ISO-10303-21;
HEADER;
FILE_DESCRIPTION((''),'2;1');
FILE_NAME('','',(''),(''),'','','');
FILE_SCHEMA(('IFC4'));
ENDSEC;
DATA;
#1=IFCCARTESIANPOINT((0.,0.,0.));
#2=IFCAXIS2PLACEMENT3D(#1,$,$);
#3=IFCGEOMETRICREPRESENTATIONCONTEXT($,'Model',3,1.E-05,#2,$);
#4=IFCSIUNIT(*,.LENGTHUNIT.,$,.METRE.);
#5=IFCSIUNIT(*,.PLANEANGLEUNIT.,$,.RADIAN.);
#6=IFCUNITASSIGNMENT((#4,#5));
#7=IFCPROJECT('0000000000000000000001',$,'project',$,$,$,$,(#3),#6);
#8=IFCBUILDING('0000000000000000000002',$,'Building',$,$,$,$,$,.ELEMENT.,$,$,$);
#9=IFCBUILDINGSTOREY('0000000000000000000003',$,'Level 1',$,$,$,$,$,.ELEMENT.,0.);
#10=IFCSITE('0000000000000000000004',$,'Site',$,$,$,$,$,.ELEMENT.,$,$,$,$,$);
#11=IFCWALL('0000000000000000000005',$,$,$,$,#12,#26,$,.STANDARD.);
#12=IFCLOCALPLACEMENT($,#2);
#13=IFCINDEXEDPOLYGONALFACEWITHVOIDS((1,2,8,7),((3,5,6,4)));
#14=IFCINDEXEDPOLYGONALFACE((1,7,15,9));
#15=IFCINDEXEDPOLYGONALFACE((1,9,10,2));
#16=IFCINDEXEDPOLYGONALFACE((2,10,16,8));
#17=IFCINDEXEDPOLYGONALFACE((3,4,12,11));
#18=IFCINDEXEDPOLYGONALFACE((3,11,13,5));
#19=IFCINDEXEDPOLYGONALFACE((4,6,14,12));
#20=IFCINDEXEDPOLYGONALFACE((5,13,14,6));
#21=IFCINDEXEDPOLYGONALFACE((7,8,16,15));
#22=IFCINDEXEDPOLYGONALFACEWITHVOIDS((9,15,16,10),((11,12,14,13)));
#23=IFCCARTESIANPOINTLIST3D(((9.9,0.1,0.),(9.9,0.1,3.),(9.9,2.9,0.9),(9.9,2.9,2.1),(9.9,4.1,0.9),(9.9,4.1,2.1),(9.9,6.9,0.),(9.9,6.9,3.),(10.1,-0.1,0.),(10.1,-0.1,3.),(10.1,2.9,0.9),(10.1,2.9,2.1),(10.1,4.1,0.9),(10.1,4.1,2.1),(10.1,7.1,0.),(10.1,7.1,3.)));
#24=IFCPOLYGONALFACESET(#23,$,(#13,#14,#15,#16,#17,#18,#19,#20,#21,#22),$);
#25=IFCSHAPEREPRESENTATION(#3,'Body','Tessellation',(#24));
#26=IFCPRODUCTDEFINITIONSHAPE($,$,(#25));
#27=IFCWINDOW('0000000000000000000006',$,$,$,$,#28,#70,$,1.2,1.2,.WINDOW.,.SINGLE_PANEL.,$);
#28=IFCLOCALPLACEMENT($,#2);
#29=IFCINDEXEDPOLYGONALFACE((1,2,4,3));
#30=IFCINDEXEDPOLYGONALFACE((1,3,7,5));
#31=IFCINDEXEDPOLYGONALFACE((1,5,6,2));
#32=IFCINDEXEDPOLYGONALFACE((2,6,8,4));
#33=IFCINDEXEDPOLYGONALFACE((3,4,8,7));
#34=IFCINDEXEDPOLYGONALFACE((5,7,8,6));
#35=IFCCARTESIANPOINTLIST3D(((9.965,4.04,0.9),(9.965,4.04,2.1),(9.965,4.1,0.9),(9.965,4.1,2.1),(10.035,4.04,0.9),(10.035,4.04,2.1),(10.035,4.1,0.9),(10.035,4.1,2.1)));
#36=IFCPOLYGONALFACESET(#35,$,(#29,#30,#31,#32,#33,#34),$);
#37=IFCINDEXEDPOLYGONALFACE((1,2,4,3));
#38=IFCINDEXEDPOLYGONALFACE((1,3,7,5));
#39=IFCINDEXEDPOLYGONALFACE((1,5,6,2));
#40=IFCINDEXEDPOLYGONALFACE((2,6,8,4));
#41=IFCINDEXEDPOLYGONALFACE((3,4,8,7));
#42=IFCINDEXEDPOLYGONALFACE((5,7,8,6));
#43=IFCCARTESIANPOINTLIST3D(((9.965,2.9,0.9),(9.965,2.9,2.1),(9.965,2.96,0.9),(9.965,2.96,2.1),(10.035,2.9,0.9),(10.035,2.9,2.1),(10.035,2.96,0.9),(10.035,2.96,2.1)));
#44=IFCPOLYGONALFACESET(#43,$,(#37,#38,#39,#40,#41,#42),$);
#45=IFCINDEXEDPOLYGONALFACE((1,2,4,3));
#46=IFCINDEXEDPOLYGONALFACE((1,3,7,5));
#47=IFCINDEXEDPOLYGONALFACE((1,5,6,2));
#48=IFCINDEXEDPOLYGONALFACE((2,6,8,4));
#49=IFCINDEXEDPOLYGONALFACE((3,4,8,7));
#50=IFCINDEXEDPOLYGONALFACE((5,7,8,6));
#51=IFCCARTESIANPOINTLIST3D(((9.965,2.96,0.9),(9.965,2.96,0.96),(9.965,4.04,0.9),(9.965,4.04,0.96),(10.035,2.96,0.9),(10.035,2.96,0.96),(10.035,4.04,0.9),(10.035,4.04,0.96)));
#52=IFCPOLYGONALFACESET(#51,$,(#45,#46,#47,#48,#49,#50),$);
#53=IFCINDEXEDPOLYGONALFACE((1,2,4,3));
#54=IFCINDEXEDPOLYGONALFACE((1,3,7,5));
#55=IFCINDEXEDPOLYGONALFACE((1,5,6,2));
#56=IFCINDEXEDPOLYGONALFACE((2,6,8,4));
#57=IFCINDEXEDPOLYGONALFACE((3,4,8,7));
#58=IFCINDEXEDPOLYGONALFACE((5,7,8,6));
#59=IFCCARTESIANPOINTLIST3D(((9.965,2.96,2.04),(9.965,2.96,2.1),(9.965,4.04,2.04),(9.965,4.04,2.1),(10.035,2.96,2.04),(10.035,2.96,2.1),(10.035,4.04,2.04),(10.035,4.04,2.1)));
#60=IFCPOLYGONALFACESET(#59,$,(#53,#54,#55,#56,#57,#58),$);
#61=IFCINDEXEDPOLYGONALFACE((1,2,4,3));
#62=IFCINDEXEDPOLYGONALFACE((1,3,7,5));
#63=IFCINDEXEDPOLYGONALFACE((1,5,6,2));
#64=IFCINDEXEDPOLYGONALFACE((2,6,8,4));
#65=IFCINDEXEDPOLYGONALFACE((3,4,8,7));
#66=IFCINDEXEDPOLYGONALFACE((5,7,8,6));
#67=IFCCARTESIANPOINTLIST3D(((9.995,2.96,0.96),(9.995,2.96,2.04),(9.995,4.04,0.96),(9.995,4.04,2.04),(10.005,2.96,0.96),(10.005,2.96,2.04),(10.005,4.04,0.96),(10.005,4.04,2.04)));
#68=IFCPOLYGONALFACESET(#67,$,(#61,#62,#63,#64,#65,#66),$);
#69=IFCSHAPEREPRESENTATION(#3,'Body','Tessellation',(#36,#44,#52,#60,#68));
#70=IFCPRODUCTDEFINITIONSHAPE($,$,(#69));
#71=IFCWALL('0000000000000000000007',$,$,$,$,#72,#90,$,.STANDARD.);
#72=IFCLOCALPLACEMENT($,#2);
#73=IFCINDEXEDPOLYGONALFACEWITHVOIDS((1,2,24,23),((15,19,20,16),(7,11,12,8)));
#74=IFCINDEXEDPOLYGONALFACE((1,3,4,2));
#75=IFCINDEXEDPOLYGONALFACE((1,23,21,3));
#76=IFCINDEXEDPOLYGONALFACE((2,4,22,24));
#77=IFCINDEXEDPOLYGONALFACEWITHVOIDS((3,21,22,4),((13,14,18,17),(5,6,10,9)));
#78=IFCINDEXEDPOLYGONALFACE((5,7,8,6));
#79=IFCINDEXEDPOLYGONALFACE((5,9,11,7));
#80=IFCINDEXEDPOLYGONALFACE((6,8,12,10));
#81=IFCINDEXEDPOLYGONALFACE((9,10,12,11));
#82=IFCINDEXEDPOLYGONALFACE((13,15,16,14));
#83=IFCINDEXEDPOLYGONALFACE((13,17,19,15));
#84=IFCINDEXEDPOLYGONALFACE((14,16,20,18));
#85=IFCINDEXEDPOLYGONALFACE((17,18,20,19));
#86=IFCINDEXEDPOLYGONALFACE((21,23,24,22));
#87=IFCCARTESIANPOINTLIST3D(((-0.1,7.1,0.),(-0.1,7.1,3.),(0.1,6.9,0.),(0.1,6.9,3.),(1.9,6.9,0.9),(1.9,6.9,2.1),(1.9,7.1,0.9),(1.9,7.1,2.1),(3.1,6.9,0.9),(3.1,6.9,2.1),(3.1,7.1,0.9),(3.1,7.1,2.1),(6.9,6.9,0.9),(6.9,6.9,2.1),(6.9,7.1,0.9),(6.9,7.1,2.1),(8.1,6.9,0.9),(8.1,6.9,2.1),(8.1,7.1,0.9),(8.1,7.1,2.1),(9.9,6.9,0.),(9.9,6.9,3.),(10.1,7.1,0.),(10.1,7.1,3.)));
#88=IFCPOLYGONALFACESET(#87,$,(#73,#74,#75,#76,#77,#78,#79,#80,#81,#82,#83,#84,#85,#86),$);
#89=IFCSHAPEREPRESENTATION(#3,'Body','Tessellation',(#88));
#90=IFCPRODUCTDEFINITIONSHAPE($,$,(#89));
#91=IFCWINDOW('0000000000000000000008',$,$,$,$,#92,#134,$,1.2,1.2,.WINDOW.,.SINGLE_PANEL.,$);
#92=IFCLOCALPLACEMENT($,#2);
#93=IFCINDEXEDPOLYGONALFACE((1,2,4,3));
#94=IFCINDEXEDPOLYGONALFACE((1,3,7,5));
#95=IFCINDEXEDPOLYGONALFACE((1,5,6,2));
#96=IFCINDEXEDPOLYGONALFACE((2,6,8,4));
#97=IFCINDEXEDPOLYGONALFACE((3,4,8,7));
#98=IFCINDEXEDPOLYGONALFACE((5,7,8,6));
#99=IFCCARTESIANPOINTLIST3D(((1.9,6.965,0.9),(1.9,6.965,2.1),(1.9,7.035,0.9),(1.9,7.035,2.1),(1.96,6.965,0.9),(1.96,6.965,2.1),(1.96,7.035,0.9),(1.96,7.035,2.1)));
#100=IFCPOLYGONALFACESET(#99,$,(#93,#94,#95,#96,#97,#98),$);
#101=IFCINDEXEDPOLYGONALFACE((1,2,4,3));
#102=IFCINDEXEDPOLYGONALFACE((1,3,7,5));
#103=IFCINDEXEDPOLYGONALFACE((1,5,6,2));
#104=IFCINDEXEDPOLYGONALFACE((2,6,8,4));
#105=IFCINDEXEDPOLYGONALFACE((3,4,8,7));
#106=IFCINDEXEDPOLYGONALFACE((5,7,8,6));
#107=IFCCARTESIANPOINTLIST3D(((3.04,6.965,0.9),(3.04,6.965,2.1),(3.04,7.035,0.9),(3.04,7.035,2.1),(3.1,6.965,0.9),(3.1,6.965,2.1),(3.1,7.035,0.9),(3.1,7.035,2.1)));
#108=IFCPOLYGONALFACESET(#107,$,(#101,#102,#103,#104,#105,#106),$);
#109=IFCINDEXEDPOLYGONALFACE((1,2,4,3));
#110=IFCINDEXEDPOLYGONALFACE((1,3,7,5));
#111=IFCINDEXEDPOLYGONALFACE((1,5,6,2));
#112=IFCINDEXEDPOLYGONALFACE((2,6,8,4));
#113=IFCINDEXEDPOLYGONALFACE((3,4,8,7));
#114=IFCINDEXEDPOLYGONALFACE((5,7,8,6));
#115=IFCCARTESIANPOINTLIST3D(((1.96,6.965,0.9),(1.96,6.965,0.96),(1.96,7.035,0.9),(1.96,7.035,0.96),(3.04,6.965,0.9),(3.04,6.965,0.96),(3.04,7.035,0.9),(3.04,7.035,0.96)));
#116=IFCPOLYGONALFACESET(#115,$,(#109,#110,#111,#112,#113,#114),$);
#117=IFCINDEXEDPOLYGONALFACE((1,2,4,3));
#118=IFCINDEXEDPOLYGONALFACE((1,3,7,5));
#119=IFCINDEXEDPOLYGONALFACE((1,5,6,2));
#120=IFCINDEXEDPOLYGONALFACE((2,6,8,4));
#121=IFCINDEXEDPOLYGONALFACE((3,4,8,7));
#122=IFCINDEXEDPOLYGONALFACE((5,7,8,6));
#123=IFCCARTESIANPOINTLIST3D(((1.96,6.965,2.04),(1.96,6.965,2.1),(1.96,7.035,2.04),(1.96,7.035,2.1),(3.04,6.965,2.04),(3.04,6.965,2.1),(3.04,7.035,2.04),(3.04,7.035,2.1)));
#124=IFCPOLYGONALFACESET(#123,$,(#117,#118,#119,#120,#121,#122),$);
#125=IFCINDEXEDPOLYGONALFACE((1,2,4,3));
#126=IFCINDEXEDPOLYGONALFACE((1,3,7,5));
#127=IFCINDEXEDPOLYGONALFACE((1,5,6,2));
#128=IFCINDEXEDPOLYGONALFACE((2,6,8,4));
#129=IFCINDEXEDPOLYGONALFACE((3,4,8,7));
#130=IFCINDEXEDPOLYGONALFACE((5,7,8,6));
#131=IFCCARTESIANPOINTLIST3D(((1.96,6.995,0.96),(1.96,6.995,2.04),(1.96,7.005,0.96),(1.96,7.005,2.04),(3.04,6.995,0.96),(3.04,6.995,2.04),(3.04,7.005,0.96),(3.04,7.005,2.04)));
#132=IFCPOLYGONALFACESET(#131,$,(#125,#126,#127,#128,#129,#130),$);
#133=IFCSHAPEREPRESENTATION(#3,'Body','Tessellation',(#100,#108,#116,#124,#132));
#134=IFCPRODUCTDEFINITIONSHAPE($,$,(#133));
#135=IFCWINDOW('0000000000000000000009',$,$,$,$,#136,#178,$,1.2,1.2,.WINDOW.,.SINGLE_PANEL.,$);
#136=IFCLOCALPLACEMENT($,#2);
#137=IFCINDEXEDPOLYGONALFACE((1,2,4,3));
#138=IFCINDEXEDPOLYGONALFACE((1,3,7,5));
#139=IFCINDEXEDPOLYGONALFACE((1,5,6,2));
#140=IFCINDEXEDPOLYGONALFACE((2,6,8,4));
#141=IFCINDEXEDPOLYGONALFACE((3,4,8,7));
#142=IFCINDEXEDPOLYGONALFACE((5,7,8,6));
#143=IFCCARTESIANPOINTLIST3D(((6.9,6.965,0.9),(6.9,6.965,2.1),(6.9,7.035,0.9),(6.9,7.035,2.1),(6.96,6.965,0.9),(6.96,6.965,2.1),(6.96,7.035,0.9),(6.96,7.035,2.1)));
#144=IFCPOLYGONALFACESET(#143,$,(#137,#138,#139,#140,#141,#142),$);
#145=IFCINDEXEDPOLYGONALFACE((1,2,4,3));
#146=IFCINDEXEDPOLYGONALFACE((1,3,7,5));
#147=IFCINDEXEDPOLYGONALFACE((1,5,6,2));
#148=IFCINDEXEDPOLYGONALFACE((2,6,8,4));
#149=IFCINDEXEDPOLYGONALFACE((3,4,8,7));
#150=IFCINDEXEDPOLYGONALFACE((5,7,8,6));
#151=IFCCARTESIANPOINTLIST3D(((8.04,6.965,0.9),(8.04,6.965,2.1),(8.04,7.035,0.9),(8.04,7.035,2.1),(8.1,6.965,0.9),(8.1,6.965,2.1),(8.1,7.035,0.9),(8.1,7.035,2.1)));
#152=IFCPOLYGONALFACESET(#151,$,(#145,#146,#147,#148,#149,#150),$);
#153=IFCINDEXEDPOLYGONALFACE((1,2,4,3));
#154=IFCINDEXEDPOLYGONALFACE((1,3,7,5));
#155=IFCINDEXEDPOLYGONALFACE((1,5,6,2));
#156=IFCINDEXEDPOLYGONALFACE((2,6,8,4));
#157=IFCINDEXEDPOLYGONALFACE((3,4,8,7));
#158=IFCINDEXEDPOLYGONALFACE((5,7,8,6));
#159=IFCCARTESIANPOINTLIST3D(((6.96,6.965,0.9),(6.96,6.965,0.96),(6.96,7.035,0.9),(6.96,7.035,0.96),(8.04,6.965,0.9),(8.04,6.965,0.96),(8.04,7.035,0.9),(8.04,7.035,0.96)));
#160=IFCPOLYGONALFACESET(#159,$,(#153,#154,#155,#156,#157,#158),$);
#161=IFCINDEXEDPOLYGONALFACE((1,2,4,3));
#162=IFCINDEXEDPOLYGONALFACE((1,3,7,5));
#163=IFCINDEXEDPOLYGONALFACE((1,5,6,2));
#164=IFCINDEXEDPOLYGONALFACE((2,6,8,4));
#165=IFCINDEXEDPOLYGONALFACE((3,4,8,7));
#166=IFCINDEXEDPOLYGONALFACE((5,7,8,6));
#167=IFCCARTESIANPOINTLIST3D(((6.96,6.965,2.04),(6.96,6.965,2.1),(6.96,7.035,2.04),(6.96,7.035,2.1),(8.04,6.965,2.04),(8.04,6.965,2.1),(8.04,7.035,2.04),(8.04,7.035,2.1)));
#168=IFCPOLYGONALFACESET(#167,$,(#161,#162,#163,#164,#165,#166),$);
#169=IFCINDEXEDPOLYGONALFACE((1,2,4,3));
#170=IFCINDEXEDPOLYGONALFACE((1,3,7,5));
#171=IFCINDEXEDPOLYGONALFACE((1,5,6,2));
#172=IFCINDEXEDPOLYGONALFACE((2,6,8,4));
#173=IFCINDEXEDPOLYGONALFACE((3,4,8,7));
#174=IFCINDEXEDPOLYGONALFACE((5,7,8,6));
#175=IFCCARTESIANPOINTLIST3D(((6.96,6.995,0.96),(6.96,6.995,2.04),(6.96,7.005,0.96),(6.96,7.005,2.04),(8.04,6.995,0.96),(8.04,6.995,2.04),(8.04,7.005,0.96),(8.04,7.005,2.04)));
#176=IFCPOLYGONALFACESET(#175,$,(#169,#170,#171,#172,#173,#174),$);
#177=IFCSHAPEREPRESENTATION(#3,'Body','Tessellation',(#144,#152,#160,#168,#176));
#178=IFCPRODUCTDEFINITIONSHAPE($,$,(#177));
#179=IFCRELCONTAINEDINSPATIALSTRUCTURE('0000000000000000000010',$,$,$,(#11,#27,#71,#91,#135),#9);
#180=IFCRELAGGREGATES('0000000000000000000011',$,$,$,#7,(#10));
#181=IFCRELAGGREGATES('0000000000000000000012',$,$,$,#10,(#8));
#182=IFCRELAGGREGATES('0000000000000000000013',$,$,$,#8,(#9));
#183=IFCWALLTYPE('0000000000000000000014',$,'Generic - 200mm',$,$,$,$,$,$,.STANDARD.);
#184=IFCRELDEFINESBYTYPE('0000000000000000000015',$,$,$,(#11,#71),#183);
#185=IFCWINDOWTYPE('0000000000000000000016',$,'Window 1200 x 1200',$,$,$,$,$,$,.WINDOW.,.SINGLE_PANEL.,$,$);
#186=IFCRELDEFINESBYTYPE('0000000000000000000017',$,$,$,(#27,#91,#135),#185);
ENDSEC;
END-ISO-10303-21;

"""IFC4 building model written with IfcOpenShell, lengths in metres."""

from ifc_helpers import new_model, si_unit, frame, frame_2d, origin, origin_with_axes, origin_2d, place, context, project, spatial, polyline, rectangle, outline, extrude, type_object, element, fill, save


model = new_model("IFC4")

# Units and contexts
model_context = context("Model", 3, precision=1e-05, world=origin())
ifc_project = project(units=[si_unit("LENGTHUNIT", "METRE"), si_unit("PLANEANGLEUNIT", "RADIAN")], contexts=[model_context])

# Site, building, storey
site = spatial("IfcSite", under=ifc_project, Name="Site", CompositionType="ELEMENT")
building = spatial("IfcBuilding", under=site, Name="Building", CompositionType="ELEMENT")
storey = spatial("IfcBuildingStorey", under=building, Name="Level 1", CompositionType="ELEMENT", Elevation=0.0)

# Shared definitions
wall_type = type_object("IfcWallType", Name="Generic - 200mm", PredefinedType="STANDARD")
window_type = type_object("IfcWindowType", Name="Window 1200 x 1200", PartitioningType="SINGLE_PANEL", PredefinedType="WINDOW")

# Wall, opening, window
wall_1_placement = place(None, frame((10.0, 7.0, 0.0), z_axis=(0.0, 0.0, 1.0), x_axis=(0.0, -1.0, 0.0)))
wall_1 = element("IfcWall", 1, at=wall_1_placement, inside=storey, type_object=wall_type, PredefinedType="STANDARD", context=model_context, shape_type="SweptSolid", body=[
    extrude(outline(polyline([(0.1, -0.1), (6.9, -0.1), (7.1, 0.1), (-0.1, 0.1), (0.1, -0.1)])), origin(), (0.0, 0.0, 1.0), 3.0),
])
opening_1_placement = place(wall_1_placement, frame((3.5, 0.0, 0.9), z_axis=(0.0, 0.0, 1.0), x_axis=(1.0, 0.0, 0.0)))
opening_1 = element("IfcOpeningElement", 2, at=opening_1_placement, cuts=wall_1, PredefinedType="OPENING", context=model_context, shape_type="SweptSolid", body=[
    extrude(rectangle(XDim=1.2, YDim=0.202, at=origin_2d()), origin(), (0.0, 0.0, 1.0), 1.2),
])
window_1_placement = place(opening_1_placement, origin_with_axes())
window_1 = element("IfcWindow", 3, at=window_1_placement, inside=storey, type_object=window_type, OverallHeight=1.2, OverallWidth=1.2, PartitioningType="SINGLE_PANEL", PredefinedType="WINDOW", context=model_context, shape_type="SweptSolid", body=[
    extrude(rectangle(XDim=0.06, YDim=0.07, at=frame_2d((-0.57, 0.0))), origin(), (0.0, 0.0, 1.0), 1.2),
    extrude(rectangle(XDim=0.06, YDim=0.07, at=frame_2d((0.57, 0.0))), origin(), (0.0, 0.0, 1.0), 1.2),
    extrude(rectangle(XDim=1.08, YDim=0.07, at=origin_2d()), origin(), (0.0, 0.0, 1.0), 0.06),
    extrude(rectangle(XDim=1.08, YDim=0.07, at=origin_2d()), frame((0.0, 0.0, 1.14)), (0.0, 0.0, 1.0), 0.06),
    extrude(rectangle(XDim=1.08, YDim=0.01, at=origin_2d()), frame((0.0, 0.0, 0.06)), (0.0, 0.0, 1.0), 1.08),
])
fill(opening_1, window_1)

# Wall, openings, windows
wall_2_placement = place(None, frame((0.0, 7.0, 0.0), z_axis=(0.0, 0.0, 1.0), x_axis=(1.0, 0.0, 0.0)))
wall_2 = element("IfcWall", 4, at=wall_2_placement, inside=storey, type_object=wall_type, PredefinedType="STANDARD", context=model_context, shape_type="SweptSolid", body=[
    extrude(outline(polyline([(0.1, -0.1), (9.9, -0.1), (10.1, 0.1), (-0.1, 0.1), (0.1, -0.1)])), origin(), (0.0, 0.0, 1.0), 3.0),
])
opening_2_placement = place(wall_2_placement, frame((2.5, 0.0, 0.9), z_axis=(0.0, 0.0, 1.0), x_axis=(1.0, 0.0, 0.0)))
opening_2 = element("IfcOpeningElement", 5, at=opening_2_placement, cuts=wall_2, PredefinedType="OPENING", context=model_context, shape_type="SweptSolid", body=[
    extrude(rectangle(XDim=1.2, YDim=0.202, at=origin_2d()), origin(), (0.0, 0.0, 1.0), 1.2),
])
opening_3_placement = place(wall_2_placement, frame((7.5, 0.0, 0.9), z_axis=(0.0, 0.0, 1.0), x_axis=(1.0, 0.0, 0.0)))
opening_3 = element("IfcOpeningElement", 6, at=opening_3_placement, cuts=wall_2, PredefinedType="OPENING", context=model_context, shape_type="SweptSolid", body=[
    extrude(rectangle(XDim=1.2, YDim=0.202, at=origin_2d()), origin(), (0.0, 0.0, 1.0), 1.2),
])
window_2_placement = place(opening_2_placement, origin_with_axes())
window_2 = element("IfcWindow", 7, at=window_2_placement, inside=storey, type_object=window_type, OverallHeight=1.2, OverallWidth=1.2, PartitioningType="SINGLE_PANEL", PredefinedType="WINDOW", context=model_context, shape_type="SweptSolid", body=[
    extrude(rectangle(XDim=0.06, YDim=0.07, at=frame_2d((-0.57, 0.0))), origin(), (0.0, 0.0, 1.0), 1.2),
    extrude(rectangle(XDim=0.06, YDim=0.07, at=frame_2d((0.57, 0.0))), origin(), (0.0, 0.0, 1.0), 1.2),
    extrude(rectangle(XDim=1.08, YDim=0.07, at=origin_2d()), origin(), (0.0, 0.0, 1.0), 0.06),
    extrude(rectangle(XDim=1.08, YDim=0.07, at=origin_2d()), frame((0.0, 0.0, 1.14)), (0.0, 0.0, 1.0), 0.06),
    extrude(rectangle(XDim=1.08, YDim=0.01, at=origin_2d()), frame((0.0, 0.0, 0.06)), (0.0, 0.0, 1.0), 1.08),
])
fill(opening_2, window_2)
window_3_placement = place(opening_3_placement, origin_with_axes())
window_3 = element("IfcWindow", 8, at=window_3_placement, inside=storey, type_object=window_type, OverallHeight=1.2, OverallWidth=1.2, PartitioningType="SINGLE_PANEL", PredefinedType="WINDOW", context=model_context, shape_type="SweptSolid", body=[
    extrude(rectangle(XDim=0.06, YDim=0.07, at=frame_2d((-0.57, 0.0))), origin(), (0.0, 0.0, 1.0), 1.2),
    extrude(rectangle(XDim=0.06, YDim=0.07, at=frame_2d((0.57, 0.0))), origin(), (0.0, 0.0, 1.0), 1.2),
    extrude(rectangle(XDim=1.08, YDim=0.07, at=origin_2d()), origin(), (0.0, 0.0, 1.0), 0.06),
    extrude(rectangle(XDim=1.08, YDim=0.07, at=origin_2d()), frame((0.0, 0.0, 1.14)), (0.0, 0.0, 1.0), 0.06),
    extrude(rectangle(XDim=1.08, YDim=0.01, at=origin_2d()), frame((0.0, 0.0, 0.06)), (0.0, 0.0, 1.0), 1.08),
])
fill(opening_3, window_3)

save(model, "model.ifc")
